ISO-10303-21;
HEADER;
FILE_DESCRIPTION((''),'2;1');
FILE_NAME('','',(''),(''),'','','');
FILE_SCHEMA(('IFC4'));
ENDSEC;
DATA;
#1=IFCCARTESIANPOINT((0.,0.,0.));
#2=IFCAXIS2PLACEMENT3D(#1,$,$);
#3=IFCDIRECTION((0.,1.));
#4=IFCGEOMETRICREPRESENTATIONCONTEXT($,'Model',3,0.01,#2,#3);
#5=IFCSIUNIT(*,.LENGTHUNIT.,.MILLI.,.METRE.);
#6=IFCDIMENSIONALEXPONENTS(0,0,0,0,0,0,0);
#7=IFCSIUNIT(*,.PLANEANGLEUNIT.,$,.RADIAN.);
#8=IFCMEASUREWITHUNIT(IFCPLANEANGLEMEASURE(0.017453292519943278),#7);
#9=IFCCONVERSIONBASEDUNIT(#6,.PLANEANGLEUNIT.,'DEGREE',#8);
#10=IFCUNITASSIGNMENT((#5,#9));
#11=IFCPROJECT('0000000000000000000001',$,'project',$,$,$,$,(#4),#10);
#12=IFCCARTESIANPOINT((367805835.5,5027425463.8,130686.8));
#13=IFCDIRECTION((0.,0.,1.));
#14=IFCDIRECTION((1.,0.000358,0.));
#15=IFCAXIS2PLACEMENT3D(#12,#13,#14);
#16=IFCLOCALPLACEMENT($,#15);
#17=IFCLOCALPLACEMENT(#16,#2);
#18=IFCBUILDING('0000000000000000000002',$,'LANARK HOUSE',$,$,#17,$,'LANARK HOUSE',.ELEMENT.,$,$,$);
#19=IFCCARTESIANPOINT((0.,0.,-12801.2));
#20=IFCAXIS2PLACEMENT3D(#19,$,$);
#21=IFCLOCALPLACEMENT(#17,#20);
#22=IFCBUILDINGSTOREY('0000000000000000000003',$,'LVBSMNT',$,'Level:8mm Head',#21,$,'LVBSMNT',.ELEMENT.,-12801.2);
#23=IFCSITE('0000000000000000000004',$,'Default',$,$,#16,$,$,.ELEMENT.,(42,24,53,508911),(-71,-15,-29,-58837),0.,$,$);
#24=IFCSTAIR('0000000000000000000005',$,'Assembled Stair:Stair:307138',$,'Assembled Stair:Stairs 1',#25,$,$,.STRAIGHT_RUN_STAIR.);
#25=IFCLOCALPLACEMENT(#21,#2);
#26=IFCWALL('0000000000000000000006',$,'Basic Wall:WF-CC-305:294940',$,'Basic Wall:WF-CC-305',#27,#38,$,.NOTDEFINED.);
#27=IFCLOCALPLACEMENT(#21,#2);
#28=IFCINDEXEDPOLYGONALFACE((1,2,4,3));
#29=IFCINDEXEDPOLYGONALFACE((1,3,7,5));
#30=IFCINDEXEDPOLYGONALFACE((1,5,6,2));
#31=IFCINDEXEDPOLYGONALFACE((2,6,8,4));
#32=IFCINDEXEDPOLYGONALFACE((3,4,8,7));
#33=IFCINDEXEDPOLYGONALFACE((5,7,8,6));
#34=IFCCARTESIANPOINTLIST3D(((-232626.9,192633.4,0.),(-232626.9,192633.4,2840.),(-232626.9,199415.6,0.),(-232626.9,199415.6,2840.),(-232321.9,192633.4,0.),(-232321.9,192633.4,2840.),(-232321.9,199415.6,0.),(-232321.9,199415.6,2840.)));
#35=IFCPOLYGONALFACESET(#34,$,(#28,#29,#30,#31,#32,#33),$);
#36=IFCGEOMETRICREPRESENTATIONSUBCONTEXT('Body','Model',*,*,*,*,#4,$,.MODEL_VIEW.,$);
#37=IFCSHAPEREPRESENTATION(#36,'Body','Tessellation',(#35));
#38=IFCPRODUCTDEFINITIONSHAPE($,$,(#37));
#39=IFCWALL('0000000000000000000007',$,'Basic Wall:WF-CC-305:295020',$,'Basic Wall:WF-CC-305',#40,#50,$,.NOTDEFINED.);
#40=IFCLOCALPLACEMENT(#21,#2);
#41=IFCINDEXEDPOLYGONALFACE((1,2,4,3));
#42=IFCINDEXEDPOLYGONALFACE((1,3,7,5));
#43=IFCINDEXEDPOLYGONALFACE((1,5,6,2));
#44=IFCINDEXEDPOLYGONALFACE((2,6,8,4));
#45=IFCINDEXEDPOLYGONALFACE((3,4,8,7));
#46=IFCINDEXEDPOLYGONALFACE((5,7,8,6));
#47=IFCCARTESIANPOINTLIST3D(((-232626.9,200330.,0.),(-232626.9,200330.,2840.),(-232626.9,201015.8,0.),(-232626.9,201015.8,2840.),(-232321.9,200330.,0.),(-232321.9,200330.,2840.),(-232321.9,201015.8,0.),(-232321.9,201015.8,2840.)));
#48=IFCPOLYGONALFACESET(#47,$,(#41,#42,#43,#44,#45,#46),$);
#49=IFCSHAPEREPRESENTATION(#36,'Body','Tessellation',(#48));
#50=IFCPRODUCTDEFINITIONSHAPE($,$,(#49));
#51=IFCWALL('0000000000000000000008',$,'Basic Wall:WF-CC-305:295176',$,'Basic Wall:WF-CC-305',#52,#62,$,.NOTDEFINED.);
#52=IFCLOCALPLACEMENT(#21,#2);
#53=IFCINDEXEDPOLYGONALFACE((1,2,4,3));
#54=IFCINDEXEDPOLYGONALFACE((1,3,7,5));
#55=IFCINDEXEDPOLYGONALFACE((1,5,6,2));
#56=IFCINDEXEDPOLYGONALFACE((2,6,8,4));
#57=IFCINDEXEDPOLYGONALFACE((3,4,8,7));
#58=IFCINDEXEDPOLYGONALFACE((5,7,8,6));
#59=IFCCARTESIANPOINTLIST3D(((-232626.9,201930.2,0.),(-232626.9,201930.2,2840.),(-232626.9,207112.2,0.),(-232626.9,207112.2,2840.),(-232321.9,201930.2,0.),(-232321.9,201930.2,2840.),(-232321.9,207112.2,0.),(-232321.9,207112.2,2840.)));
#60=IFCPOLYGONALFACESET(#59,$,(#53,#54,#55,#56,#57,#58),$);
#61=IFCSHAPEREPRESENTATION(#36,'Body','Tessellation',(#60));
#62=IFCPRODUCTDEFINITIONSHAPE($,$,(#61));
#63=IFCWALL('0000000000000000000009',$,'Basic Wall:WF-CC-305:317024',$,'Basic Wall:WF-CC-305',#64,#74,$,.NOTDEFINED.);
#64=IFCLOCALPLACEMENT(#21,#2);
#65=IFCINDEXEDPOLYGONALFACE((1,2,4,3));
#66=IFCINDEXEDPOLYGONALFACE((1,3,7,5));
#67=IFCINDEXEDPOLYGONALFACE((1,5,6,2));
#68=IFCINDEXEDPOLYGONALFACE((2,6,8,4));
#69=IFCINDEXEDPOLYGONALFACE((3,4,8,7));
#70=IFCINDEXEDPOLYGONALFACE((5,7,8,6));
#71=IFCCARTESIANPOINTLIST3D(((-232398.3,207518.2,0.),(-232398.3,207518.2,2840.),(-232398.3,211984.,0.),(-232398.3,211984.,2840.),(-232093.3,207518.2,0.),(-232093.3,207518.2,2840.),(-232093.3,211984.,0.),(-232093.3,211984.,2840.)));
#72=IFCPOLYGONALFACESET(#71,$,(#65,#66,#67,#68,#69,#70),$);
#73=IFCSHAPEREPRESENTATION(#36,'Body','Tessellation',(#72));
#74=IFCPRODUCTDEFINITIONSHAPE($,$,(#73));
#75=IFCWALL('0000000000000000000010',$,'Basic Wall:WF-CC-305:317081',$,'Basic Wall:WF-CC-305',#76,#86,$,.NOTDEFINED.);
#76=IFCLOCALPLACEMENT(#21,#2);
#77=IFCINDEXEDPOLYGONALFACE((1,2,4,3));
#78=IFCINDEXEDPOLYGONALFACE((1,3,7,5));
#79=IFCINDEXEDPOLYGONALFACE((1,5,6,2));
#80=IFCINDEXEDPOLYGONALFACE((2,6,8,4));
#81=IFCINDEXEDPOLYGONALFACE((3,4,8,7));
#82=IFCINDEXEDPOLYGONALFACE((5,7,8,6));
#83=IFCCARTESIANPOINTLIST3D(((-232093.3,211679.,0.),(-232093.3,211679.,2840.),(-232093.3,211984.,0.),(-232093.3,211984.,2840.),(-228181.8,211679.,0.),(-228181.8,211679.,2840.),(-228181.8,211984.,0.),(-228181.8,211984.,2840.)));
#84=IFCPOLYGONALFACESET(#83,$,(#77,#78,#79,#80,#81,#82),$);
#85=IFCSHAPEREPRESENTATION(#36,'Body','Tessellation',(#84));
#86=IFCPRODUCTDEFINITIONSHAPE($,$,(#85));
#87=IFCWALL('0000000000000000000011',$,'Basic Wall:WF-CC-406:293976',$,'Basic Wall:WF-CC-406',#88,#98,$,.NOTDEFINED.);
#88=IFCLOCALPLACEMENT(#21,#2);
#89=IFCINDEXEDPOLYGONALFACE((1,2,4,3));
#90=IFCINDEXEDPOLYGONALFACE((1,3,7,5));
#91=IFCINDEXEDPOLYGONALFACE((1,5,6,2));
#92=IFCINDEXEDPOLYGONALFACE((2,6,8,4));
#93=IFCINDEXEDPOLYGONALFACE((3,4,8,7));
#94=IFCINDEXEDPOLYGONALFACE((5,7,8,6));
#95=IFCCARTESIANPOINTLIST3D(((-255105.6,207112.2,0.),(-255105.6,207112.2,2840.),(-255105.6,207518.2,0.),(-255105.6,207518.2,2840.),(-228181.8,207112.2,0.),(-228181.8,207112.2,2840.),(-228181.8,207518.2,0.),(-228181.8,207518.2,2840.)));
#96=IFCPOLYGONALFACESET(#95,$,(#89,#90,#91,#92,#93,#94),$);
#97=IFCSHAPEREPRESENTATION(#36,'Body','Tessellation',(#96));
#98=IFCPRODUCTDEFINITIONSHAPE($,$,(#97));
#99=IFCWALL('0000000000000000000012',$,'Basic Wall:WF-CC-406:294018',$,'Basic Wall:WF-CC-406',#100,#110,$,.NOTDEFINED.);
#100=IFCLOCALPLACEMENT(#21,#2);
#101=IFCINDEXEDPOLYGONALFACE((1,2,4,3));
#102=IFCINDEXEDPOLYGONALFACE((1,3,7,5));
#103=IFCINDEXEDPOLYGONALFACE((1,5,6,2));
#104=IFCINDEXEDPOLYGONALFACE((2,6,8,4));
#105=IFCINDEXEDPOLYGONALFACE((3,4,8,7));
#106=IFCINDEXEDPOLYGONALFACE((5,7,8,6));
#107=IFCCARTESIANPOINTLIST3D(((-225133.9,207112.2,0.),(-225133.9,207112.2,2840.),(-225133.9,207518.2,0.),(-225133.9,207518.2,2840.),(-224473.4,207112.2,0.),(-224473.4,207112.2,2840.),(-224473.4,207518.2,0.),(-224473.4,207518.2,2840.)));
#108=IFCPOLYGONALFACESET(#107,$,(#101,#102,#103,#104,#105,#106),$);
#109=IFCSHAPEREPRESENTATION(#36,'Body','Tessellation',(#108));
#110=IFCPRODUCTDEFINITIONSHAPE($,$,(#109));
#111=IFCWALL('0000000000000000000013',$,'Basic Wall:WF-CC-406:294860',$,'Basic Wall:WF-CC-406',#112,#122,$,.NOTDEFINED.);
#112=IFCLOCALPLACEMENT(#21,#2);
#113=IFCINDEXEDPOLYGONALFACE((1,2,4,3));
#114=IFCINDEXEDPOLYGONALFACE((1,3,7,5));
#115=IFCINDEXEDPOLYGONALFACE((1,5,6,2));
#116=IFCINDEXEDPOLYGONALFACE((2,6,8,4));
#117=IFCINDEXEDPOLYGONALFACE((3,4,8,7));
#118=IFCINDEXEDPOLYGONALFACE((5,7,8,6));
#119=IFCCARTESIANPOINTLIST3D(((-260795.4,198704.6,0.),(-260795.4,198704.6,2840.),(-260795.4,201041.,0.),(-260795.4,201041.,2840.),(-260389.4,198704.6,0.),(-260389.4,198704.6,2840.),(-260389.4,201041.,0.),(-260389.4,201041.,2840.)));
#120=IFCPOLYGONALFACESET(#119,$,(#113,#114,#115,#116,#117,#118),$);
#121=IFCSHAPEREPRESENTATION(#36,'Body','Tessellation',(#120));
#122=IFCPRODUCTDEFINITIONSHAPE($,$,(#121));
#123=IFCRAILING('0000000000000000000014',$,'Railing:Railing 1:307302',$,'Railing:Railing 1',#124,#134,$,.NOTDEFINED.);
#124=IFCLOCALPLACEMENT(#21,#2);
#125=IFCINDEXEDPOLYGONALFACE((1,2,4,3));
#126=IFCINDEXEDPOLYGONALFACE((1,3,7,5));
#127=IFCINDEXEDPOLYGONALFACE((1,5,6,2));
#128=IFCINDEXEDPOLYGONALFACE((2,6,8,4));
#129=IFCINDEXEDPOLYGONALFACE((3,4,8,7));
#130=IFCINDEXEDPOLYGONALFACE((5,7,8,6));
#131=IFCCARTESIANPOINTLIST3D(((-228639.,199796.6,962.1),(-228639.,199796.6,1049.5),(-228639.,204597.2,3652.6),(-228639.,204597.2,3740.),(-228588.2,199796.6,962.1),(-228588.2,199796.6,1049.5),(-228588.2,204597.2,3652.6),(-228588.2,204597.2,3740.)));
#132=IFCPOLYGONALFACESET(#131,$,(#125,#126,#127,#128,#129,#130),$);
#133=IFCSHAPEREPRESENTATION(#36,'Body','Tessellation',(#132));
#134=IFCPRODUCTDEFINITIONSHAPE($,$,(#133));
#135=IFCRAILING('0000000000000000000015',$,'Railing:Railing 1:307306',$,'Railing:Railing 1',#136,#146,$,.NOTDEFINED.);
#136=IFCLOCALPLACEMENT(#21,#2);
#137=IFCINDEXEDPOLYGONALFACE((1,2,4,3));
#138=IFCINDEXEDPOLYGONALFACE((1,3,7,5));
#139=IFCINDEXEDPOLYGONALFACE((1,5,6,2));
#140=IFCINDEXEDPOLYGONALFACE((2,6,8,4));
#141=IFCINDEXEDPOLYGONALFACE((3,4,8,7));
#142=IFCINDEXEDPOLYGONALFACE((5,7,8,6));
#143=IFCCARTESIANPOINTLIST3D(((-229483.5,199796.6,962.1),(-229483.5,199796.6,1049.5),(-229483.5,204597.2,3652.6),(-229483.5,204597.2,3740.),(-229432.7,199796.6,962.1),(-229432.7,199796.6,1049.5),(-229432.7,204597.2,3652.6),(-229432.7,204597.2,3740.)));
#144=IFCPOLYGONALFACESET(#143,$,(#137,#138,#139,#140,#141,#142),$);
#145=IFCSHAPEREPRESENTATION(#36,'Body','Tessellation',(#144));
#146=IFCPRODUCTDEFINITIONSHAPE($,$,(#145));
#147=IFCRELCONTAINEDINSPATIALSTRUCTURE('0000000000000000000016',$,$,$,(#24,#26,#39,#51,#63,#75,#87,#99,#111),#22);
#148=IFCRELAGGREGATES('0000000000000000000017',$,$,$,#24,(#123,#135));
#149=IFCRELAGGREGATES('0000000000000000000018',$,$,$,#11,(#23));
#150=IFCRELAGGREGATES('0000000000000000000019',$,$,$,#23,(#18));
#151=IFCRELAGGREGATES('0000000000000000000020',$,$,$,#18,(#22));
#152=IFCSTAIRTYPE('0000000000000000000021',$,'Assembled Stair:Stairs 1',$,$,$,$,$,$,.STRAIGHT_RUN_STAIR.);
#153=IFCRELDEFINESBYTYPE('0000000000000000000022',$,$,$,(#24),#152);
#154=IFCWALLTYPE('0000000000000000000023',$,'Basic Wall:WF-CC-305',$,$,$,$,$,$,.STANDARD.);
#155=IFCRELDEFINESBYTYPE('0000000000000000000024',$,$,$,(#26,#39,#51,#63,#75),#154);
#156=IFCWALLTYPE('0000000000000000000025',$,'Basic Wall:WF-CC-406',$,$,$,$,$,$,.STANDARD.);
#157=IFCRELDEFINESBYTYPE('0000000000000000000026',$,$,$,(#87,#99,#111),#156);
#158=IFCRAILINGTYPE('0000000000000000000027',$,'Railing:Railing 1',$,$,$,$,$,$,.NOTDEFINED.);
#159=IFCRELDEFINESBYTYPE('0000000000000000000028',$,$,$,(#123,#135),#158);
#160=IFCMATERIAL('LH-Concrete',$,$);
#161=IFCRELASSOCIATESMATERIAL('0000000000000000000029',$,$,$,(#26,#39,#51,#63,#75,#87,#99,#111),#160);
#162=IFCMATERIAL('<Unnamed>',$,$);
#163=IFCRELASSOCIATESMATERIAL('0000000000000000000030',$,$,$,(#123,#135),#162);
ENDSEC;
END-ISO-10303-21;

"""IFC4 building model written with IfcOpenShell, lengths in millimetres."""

from ifc_helpers import new_model, entity, si_unit, converted_unit, direction, frame, origin, place, context, subcontext, project, spatial, indexed_curve, outline, extrude, material, type_object, element, aggregate, save


model = new_model("IFC4")

# Units and contexts
model_context = context("Model", 3, precision=0.01, world=origin(), true_north=direction((0.0, 1.0)))
body_context = subcontext(model_context, "Body", "Model", "MODEL_VIEW")
ifc_project = project(units=[si_unit("LENGTHUNIT", "METRE", prefix="MILLI"), converted_unit("PLANEANGLEUNIT", "DEGREE", entity("IfcPlaneAngleMeasure", 0.017453292519943278), si_unit("PLANEANGLEUNIT", "RADIAN"), dimensions=[0, 0, 0, 0, 0, 0, 0])], contexts=[model_context])

# Site, building, storey
site_placement = place(None, frame((367805835.5, 5027425463.8, 130686.8), z_axis=(0.0, 0.0, 1.0), x_axis=(1.0, 0.000358, 0.0)))
site = spatial("IfcSite", under=ifc_project, at=site_placement, Name="Default", CompositionType="ELEMENT", RefLatitude=(42, 24, 53, 508911), RefLongitude=(-71, -15, -29, -58837), RefElevation=0.0)
building_placement = place(site_placement, origin())
building = spatial("IfcBuilding", under=site, at=building_placement, Name="LANARK HOUSE", LongName="LANARK HOUSE", CompositionType="ELEMENT")
storey_placement = place(building_placement, frame((0.0, 0.0, -12801.2)))
storey = spatial("IfcBuildingStorey", under=building, at=storey_placement, Name="LVBSMNT", ObjectType="Level:8mm Head", LongName="LVBSMNT", CompositionType="ELEMENT", Elevation=-12801.2)

# Stair
stair_type = type_object("IfcStairType", Name="Assembled Stair:Stairs 1", PredefinedType="STRAIGHT_RUN_STAIR")
stair_placement = place(storey_placement, origin())
stair = element("IfcStair", 1, at=stair_placement, inside=storey, type_object=stair_type, Name="Assembled Stair:Stair:307138", ObjectType="Assembled Stair:Stairs 1", PredefinedType="STRAIGHT_RUN_STAIR")
ifc_material_1 = material(Name="<Unnamed>")

# Walls
ifc_material_2 = material(Name="LH-Concrete")
wall_type_1 = type_object("IfcWallType", Name="Basic Wall:WF-CC-305", PredefinedType="STANDARD")
wall_1_placement = place(storey_placement, frame((-232474.4, 199415.6, 0.0), z_axis=(0.0, 0.0, 1.0), x_axis=(0.0, -1.0, 0.0)))
element("IfcWall", 2, at=wall_1_placement, inside=storey, type_object=wall_type_1, material=ifc_material_2, Name="Basic Wall:WF-CC-305:294940", ObjectType="Basic Wall:WF-CC-305", PredefinedType="NOTDEFINED", context=body_context, shape_type="SweptSolid", body=[
    extrude(outline(indexed_curve([(6782.2, 152.5), (0.0, 152.5), (0.0, -152.5), (6782.2, -152.5), (6782.2, 152.5)], self_intersect=False)), origin(), (0.0, 0.0, 1.0), 2840.0),
])
wall_2_placement = place(storey_placement, frame((-232474.4, 201015.8, 0.0), z_axis=(0.0, 0.0, 1.0), x_axis=(0.0, -1.0, 0.0)))
element("IfcWall", 3, at=wall_2_placement, inside=storey, type_object=wall_type_1, material=ifc_material_2, Name="Basic Wall:WF-CC-305:295020", ObjectType="Basic Wall:WF-CC-305", PredefinedType="NOTDEFINED", context=body_context, shape_type="SweptSolid", body=[
    extrude(outline(indexed_curve([(685.8, 152.5), (0.0, 152.5), (0.0, -152.5), (685.8, -152.5), (685.8, 152.5)], self_intersect=False)), origin(), (0.0, 0.0, 1.0), 2840.0),
])
wall_3_placement = place(storey_placement, frame((-232474.4, 201930.2, 0.0), z_axis=(0.0, 0.0, 1.0), x_axis=(0.0, 1.0, 0.0)))
element("IfcWall", 4, at=wall_3_placement, inside=storey, type_object=wall_type_1, material=ifc_material_2, Name="Basic Wall:WF-CC-305:295176", ObjectType="Basic Wall:WF-CC-305", PredefinedType="NOTDEFINED", context=body_context, shape_type="SweptSolid", body=[
    extrude(outline(indexed_curve([(5182.0, 152.5), (0.0, 152.5), (0.0, -152.5), (5182.0, -152.5), (5182.0, 152.5)], self_intersect=False)), origin(), (0.0, 0.0, 1.0), 2840.0),
])
wall_4_placement = place(storey_placement, frame((-232245.8, 207518.2, 0.0), z_axis=(0.0, 0.0, 1.0), x_axis=(0.0, 1.0, 0.0)))
element("IfcWall", 5, at=wall_4_placement, inside=storey, type_object=wall_type_1, material=ifc_material_2, Name="Basic Wall:WF-CC-305:317024", ObjectType="Basic Wall:WF-CC-305", PredefinedType="NOTDEFINED", context=body_context, shape_type="SweptSolid", body=[
    extrude(outline(indexed_curve([(4465.7, 152.5), (0.0, 152.5), (0.0, -152.5), (4465.7, -152.5), (4465.7, 152.5)], self_intersect=False)), origin(), (0.0, 0.0, 1.0), 2840.0),
])
wall_5_placement = place(storey_placement, frame((-232093.3, 211831.5, 0.0)))
element("IfcWall", 6, at=wall_5_placement, inside=storey, type_object=wall_type_1, material=ifc_material_2, Name="Basic Wall:WF-CC-305:317081", ObjectType="Basic Wall:WF-CC-305", PredefinedType="NOTDEFINED", context=body_context, shape_type="SweptSolid", body=[
    extrude(outline(indexed_curve([(3911.5, 152.5), (0.0, 152.5), (0.0, -152.5), (3911.5, -152.5), (3911.5, 152.5)], self_intersect=False)), origin(), (0.0, 0.0, 1.0), 2840.0),
])
wall_type_2 = type_object("IfcWallType", Name="Basic Wall:WF-CC-406", PredefinedType="STANDARD")
wall_6_placement = place(storey_placement, frame((-255105.6, 207315.2, 0.0)))
element("IfcWall", 7, at=wall_6_placement, inside=storey, type_object=wall_type_2, material=ifc_material_2, Name="Basic Wall:WF-CC-406:293976", ObjectType="Basic Wall:WF-CC-406", PredefinedType="NOTDEFINED", context=body_context, shape_type="SweptSolid", body=[
    extrude(outline(indexed_curve([(26923.8, 203.0), (0.0, 203.0), (0.0, -203.0), (26923.8, -203.0), (26923.8, 203.0)], self_intersect=False)), origin(), (0.0, 0.0, 1.0), 2840.0),
])
wall_7_placement = place(storey_placement, frame((-225133.9, 207315.2, 0.0)))
element("IfcWall", 8, at=wall_7_placement, inside=storey, type_object=wall_type_2, material=ifc_material_2, Name="Basic Wall:WF-CC-406:294018", ObjectType="Basic Wall:WF-CC-406", PredefinedType="NOTDEFINED", context=body_context, shape_type="SweptSolid", body=[
    extrude(outline(indexed_curve([(660.5, 203.0), (0.0, 203.0), (0.0, -203.0), (660.5, -203.0), (660.5, 203.0)], self_intersect=False)), origin(), (0.0, 0.0, 1.0), 2840.0),
])
wall_8_placement = place(storey_placement, frame((-260592.4, 198704.6, 0.0), z_axis=(0.0, 0.0, 1.0), x_axis=(0.0, 1.0, 0.0)))
element("IfcWall", 9, at=wall_8_placement, inside=storey, type_object=wall_type_2, material=ifc_material_2, Name="Basic Wall:WF-CC-406:294860", ObjectType="Basic Wall:WF-CC-406", PredefinedType="NOTDEFINED", context=body_context, shape_type="SweptSolid", body=[
    extrude(outline(indexed_curve([(2336.4, 203.0), (0.0, 203.0), (0.0, -203.0), (2336.4, -203.0), (2336.4, 203.0)], self_intersect=False)), origin(), (0.0, 0.0, 1.0), 2840.0),
])

# Railings
railing_type = type_object("IfcRailingType", Name="Railing:Railing 1", PredefinedType="NOTDEFINED")
railing_1_placement = place(stair_placement, frame((-228639.0, 199796.6, 962.1)))
railing_1 = element("IfcRailing", 10, at=railing_1_placement, type_object=railing_type, material=ifc_material_1, Name="Railing:Railing 1:307302", ObjectType="Railing:Railing 1", PredefinedType="NOTDEFINED", context=body_context, shape_type="SweptSolid", body=[
    extrude(outline(indexed_curve([(-2772.9, -38.1), (2730.2, -38.1), (2772.9, 38.1), (-2730.2, 38.1), (-2772.9, -38.1)], self_intersect=False)), frame((0.0, 2400.3, 1388.9), z_axis=(1.0, 0.0, 0.0), x_axis=(0.0, 0.872336, 0.488906)), (0.0, 0.0, 1.0), 50.8),
])
railing_2_placement = place(stair_placement, frame((-229483.5, 199796.6, 962.1)))
railing_2 = element("IfcRailing", 11, at=railing_2_placement, type_object=railing_type, material=ifc_material_1, Name="Railing:Railing 1:307306", ObjectType="Railing:Railing 1", PredefinedType="NOTDEFINED", context=body_context, shape_type="SweptSolid", body=[
    extrude(outline(indexed_curve([(-2772.9, -38.1), (2730.2, -38.1), (2772.9, 38.1), (-2730.2, 38.1), (-2772.9, -38.1)], self_intersect=False)), frame((0.0, 2400.3, 1388.9), z_axis=(1.0, 0.0, 0.0), x_axis=(0.0, 0.872336, 0.488906)), (0.0, 0.0, 1.0), 50.8),
])
aggregate(stair, [railing_1, railing_2])

save(model, "model.ifc")
